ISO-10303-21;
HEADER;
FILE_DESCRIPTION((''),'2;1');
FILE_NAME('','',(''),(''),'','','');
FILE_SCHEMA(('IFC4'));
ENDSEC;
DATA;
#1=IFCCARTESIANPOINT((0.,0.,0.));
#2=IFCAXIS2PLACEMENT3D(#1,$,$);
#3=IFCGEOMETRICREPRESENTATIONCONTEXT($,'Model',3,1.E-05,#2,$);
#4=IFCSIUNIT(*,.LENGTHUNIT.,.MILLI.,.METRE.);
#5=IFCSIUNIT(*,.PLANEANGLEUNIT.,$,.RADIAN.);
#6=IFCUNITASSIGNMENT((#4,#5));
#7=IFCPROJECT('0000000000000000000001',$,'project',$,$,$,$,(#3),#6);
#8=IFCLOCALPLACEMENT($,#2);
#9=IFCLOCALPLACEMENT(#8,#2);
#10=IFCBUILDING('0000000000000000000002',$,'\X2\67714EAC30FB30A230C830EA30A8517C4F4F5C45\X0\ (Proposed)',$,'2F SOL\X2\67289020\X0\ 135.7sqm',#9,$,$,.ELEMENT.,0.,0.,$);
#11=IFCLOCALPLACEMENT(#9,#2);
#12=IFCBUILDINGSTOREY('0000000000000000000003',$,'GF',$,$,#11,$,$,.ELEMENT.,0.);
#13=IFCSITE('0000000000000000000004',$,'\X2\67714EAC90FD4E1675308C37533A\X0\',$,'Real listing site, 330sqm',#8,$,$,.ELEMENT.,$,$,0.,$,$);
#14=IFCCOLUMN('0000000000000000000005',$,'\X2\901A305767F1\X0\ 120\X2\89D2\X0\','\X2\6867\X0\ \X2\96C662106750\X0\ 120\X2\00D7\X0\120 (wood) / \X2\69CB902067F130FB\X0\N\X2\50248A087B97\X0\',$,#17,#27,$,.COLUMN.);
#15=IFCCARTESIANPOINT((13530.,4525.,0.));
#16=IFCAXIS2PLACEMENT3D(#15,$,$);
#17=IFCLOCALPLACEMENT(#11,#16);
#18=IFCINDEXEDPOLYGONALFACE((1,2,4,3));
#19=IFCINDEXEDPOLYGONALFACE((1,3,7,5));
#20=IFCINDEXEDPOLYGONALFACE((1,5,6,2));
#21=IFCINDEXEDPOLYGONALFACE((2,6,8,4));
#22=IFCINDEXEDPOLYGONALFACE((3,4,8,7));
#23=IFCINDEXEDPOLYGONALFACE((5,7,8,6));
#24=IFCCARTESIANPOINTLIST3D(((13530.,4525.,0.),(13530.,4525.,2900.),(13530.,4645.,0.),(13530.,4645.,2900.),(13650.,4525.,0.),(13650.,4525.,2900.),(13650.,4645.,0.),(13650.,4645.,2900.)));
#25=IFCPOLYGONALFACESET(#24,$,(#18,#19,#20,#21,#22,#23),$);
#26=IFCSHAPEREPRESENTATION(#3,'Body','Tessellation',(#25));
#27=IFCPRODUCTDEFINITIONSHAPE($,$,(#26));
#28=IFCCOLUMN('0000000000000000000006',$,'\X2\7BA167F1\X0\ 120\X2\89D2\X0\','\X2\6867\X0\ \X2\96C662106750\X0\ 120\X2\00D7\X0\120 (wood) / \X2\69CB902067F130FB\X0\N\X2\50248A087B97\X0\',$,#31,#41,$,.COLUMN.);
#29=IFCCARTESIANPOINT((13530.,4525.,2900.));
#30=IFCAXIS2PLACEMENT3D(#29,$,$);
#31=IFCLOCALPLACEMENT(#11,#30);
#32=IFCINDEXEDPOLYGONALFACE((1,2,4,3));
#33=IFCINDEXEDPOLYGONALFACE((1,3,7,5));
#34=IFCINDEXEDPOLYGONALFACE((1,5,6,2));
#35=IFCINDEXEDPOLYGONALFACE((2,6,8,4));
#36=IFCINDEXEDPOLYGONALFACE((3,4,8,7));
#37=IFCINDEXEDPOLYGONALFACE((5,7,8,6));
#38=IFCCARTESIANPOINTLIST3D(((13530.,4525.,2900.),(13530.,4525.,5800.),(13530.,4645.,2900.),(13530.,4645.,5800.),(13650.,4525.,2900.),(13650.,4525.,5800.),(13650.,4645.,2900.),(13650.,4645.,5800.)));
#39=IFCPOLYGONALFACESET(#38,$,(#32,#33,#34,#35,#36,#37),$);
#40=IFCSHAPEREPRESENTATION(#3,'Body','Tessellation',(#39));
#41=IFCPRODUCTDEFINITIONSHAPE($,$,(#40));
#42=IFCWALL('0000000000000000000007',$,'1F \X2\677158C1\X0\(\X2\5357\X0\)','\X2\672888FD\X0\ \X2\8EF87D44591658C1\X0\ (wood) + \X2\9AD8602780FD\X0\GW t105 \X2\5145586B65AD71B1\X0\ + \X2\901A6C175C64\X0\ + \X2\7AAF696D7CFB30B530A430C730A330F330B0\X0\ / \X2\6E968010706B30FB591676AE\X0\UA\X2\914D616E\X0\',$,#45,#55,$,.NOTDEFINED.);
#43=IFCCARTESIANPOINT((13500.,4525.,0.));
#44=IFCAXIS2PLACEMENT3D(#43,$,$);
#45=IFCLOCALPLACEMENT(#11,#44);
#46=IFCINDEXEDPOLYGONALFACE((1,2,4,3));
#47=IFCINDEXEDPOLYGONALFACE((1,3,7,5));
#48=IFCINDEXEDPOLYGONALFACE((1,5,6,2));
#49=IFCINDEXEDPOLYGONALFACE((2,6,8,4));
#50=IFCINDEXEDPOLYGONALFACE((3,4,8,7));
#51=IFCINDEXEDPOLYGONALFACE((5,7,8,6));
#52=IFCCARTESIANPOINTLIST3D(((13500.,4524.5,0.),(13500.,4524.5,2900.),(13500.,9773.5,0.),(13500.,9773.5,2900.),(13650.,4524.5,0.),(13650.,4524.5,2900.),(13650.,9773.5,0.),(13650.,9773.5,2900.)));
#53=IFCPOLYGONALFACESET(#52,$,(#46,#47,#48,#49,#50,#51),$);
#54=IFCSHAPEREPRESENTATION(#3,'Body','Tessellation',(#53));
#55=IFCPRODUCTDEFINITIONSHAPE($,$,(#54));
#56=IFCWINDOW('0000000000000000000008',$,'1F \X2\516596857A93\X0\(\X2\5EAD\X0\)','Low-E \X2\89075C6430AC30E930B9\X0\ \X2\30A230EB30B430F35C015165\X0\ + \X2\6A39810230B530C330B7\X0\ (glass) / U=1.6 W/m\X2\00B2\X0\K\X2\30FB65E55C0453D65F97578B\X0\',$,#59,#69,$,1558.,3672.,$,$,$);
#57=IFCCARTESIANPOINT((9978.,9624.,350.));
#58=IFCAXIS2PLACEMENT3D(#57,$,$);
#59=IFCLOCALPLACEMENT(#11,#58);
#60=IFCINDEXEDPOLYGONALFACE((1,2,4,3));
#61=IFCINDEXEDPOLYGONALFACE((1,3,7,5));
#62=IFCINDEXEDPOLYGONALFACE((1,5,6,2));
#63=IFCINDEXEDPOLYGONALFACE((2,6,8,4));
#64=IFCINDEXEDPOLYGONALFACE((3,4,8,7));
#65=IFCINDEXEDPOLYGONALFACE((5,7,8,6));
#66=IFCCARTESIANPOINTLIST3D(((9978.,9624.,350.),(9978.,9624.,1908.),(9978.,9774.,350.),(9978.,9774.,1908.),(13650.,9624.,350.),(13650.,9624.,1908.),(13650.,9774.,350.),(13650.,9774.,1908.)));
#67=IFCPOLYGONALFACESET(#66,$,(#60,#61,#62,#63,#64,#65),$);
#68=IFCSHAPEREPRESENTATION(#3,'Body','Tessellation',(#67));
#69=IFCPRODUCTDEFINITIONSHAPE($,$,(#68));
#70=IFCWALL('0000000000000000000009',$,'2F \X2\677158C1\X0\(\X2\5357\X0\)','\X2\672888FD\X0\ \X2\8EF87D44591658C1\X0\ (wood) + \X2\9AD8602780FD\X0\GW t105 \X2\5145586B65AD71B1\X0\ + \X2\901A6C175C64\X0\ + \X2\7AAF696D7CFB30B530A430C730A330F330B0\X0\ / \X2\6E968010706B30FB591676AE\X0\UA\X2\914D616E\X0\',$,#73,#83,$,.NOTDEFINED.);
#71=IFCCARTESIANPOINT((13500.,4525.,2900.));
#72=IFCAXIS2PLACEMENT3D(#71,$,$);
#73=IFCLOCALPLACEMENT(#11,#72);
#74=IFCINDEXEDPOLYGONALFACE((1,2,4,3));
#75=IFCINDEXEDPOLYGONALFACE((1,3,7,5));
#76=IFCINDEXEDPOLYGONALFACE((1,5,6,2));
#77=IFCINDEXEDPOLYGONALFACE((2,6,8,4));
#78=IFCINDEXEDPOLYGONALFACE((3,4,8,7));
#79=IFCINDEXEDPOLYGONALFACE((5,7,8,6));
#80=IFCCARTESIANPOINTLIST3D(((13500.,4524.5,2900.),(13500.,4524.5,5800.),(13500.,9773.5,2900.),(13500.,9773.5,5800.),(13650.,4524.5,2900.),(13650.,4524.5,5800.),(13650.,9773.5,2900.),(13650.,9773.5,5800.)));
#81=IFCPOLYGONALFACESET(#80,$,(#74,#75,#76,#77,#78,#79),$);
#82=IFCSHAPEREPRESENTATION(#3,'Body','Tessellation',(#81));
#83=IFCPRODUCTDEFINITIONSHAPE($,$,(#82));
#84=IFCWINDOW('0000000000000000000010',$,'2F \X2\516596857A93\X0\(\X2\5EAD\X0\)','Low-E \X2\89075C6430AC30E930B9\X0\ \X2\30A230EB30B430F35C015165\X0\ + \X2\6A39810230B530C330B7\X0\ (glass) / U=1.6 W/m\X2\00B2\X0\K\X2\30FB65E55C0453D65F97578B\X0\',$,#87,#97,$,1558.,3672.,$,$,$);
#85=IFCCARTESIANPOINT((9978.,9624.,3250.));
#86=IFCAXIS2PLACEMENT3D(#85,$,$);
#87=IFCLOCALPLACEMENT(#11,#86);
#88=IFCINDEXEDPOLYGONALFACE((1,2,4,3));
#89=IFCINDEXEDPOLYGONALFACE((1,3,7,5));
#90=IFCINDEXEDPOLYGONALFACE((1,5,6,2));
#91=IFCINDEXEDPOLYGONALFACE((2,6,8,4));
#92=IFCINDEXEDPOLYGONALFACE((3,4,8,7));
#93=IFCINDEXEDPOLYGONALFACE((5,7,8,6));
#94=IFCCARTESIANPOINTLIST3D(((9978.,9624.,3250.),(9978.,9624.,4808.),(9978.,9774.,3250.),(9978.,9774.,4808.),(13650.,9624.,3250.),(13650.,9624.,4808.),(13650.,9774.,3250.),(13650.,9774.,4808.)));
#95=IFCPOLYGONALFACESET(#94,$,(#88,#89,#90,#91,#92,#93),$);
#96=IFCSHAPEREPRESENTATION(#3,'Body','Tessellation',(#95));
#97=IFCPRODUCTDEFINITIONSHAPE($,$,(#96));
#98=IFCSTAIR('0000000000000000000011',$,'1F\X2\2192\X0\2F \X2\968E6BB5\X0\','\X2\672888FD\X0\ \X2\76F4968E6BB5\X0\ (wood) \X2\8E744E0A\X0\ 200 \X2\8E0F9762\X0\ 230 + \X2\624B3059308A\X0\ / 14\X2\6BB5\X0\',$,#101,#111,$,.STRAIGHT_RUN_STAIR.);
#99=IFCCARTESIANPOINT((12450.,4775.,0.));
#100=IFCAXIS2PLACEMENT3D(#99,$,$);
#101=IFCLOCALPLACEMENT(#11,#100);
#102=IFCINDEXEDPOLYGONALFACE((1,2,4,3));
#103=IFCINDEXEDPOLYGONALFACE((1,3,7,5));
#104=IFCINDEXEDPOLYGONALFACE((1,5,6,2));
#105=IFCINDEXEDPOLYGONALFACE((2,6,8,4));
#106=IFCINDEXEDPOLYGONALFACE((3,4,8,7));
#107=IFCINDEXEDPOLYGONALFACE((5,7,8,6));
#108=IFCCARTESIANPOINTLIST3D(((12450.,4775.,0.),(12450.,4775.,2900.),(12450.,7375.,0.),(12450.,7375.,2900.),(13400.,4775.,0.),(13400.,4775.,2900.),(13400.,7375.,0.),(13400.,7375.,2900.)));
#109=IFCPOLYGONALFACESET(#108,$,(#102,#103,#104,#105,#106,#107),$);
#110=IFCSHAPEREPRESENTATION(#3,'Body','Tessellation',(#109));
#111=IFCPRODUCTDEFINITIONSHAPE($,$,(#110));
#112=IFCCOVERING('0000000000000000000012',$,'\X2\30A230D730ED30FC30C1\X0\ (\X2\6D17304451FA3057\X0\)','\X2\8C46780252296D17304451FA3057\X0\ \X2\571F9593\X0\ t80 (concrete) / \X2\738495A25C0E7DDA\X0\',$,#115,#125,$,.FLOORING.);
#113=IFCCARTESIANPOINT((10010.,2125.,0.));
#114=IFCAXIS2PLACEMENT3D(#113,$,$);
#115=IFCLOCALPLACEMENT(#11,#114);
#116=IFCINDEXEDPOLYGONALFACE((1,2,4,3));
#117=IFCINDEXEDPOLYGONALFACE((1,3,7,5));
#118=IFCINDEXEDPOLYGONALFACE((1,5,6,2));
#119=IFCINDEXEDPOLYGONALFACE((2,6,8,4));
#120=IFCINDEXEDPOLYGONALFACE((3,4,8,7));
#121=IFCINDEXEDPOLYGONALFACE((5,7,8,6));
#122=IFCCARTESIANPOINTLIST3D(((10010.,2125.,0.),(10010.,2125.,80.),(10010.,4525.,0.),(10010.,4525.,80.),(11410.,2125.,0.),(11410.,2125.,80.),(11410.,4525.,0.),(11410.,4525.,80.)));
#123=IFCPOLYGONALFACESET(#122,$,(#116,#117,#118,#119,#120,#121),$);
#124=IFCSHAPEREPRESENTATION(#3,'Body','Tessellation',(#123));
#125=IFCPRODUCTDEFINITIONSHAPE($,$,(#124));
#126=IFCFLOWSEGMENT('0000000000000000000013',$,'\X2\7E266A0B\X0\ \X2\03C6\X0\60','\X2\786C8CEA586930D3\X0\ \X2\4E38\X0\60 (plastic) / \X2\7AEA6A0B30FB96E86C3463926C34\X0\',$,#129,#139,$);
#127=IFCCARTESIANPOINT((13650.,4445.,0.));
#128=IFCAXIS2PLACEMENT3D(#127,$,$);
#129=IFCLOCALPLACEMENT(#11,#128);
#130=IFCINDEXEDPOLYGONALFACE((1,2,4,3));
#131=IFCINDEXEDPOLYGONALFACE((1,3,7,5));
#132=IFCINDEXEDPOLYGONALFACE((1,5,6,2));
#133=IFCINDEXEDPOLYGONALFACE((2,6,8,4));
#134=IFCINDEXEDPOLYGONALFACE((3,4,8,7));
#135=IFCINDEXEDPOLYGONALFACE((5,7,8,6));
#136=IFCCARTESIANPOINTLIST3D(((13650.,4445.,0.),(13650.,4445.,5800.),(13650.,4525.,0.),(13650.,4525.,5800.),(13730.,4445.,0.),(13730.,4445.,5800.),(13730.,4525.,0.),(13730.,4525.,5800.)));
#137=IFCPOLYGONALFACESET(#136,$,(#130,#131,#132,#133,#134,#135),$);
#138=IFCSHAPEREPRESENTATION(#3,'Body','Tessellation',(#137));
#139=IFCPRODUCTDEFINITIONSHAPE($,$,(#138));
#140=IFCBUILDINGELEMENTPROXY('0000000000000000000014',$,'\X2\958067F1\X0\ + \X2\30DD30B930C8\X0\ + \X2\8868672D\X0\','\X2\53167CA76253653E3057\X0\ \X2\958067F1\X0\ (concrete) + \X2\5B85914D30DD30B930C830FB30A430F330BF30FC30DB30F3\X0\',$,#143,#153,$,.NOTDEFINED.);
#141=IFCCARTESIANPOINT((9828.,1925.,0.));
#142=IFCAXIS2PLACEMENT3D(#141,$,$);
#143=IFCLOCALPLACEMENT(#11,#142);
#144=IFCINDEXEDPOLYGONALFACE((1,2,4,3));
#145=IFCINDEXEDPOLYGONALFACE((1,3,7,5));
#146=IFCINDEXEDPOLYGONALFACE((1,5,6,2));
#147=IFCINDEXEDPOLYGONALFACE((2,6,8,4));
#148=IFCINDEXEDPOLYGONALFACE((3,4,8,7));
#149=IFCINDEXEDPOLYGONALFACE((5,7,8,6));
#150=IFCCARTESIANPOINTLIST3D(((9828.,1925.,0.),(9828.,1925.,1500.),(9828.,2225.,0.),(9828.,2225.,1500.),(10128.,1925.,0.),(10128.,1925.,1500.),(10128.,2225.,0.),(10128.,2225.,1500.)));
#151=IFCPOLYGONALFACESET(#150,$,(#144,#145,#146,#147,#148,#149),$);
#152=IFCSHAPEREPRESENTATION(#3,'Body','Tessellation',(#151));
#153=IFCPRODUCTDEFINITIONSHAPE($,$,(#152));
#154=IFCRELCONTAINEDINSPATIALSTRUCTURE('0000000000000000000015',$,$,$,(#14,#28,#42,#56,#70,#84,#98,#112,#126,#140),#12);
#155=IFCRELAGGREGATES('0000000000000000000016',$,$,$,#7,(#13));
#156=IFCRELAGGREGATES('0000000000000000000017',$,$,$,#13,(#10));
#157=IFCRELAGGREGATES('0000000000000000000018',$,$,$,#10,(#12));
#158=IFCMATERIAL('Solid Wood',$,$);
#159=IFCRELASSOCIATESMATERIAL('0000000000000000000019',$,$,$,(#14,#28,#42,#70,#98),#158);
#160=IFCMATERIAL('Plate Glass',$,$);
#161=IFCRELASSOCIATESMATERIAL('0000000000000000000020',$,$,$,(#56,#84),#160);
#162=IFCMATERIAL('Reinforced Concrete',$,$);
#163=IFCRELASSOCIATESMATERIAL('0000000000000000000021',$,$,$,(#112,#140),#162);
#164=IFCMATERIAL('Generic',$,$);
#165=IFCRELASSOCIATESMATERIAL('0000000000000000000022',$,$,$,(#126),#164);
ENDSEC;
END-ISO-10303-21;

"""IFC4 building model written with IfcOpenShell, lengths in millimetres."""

from ifc_helpers import new_model, si_unit, frame, frame_2d, origin, place, context, project, spatial, rectangle, extrude, material, element, fill, save


model = new_model("IFC4")

# Units and contexts
model_context = context("Model", 3, precision=1e-05, world=origin())
ifc_project = project(units=[si_unit("LENGTHUNIT", "METRE", prefix="MILLI"), si_unit("PLANEANGLEUNIT", "RADIAN")], contexts=[model_context])

# Site, building, storey
site_placement = place(None, origin())
site = spatial("IfcSite", under=ifc_project, at=site_placement, Name="東京都世田谷区", ObjectType="Real listing site, 330sqm", CompositionType="ELEMENT", RefElevation=0.0)
building_placement = place(site_placement, origin())
building = spatial("IfcBuilding", under=site, at=building_placement, Name="東京・アトリエ兼住居 (Proposed)", ObjectType="2F SOL木造 135.7sqm", CompositionType="ELEMENT", ElevationOfRefHeight=0.0, ElevationOfTerrain=0.0)
storey_placement = place(building_placement, origin())
storey = spatial("IfcBuildingStorey", under=building, at=storey_placement, Name="GF", CompositionType="ELEMENT", Elevation=0.0)

# Columns
ifc_material_1 = material(Name="Solid Wood")
column_1_placement = place(storey_placement, frame((13530.0, 4525.0, 0.0)))
element("IfcColumn", 1, at=column_1_placement, inside=storey, material=ifc_material_1, Name="通し柱 120角", Description="桧 集成材 120×120 (wood) / 構造柱・N値計算", PredefinedType="COLUMN", context=model_context, shape_type="SweptSolid", body=[
    extrude(rectangle(XDim=120.0, YDim=120.0, at=frame_2d((60.0, 60.0))), frame((13530.0, 4525.0, 0.0)), (0.0, 0.0, 1.0), 2900.0),
])
column_2_placement = place(storey_placement, frame((13530.0, 4525.0, 2900.0)))
element("IfcColumn", 2, at=column_2_placement, inside=storey, material=ifc_material_1, Name="管柱 120角", Description="桧 集成材 120×120 (wood) / 構造柱・N値計算", PredefinedType="COLUMN", context=model_context, shape_type="SweptSolid", body=[
    extrude(rectangle(XDim=120.0, YDim=120.0, at=frame_2d((60.0, 60.0))), frame((13530.0, 4525.0, 2900.0)), (0.0, 0.0, 1.0), 2900.0),
])

# Wall, opening, window
wall_1_placement = place(storey_placement, frame((13500.0, 4525.0, 0.0)))
wall_1 = element("IfcWall", 3, at=wall_1_placement, inside=storey, material=ifc_material_1, Name="1F 東壁(南)", Description="木製 軸組外壁 (wood) + 高性能GW t105 充填断熱 + 通気層 + 窯業系サイディング / 準耐火・外皮UA配慮", PredefinedType="NOTDEFINED", context=model_context, shape_type="SweptSolid", body=[
    extrude(rectangle(XDim=150.0, YDim=5249.0, at=frame_2d((75.0, 2624.0))), frame((13500.0, 4525.0, 0.0)), (0.0, 0.0, 1.0), 2900.0),
])
opening_1_placement = place(storey_placement, frame((9978.0, 9624.0, 350.0)))
opening_1 = element("IfcOpeningElement", 4, at=opening_1_placement, cuts=wall_1, PredefinedType="NOTDEFINED", context=model_context, shape_type="SweptSolid", body=[
    extrude(rectangle(XDim=3672.0, YDim=150.0, at=frame_2d((1836.0, 75.0))), frame((9978.0, 9624.0, 350.0)), (0.0, 0.0, 1.0), 1558.0),
])
ifc_material_2 = material(Name="Plate Glass")
window_1_placement = place(storey_placement, frame((9978.0, 9624.0, 350.0)))
window_1 = element("IfcWindow", 5, at=window_1_placement, inside=storey, material=ifc_material_2, Name="1F 入隅窓(庭)", Description="Low-E 複層ガラス アルゴン封入 + 樹脂サッシ (glass) / U=1.6 W/m²K・日射取得型", OverallHeight=1558.0, OverallWidth=3672.0, context=model_context, shape_type="SweptSolid", body=[
    extrude(rectangle(XDim=3672.0, YDim=150.0, at=frame_2d((1836.0, 75.0))), frame((9978.0, 9624.0, 350.0)), (0.0, 0.0, 1.0), 1558.0),
])
fill(opening_1, window_1)

# Wall, opening, window
wall_2_placement = place(storey_placement, frame((13500.0, 4525.0, 2900.0)))
wall_2 = element("IfcWall", 6, at=wall_2_placement, inside=storey, material=ifc_material_1, Name="2F 東壁(南)", Description="木製 軸組外壁 (wood) + 高性能GW t105 充填断熱 + 通気層 + 窯業系サイディング / 準耐火・外皮UA配慮", PredefinedType="NOTDEFINED", context=model_context, shape_type="SweptSolid", body=[
    extrude(rectangle(XDim=150.0, YDim=5249.0, at=frame_2d((75.0, 2624.0))), frame((13500.0, 4525.0, 2900.0)), (0.0, 0.0, 1.0), 2900.0),
])
opening_2_placement = place(storey_placement, frame((9978.0, 9624.0, 3250.0)))
opening_2 = element("IfcOpeningElement", 7, at=opening_2_placement, cuts=wall_2, PredefinedType="NOTDEFINED", context=model_context, shape_type="SweptSolid", body=[
    extrude(rectangle(XDim=3672.0, YDim=150.0, at=frame_2d((1836.0, 75.0))), frame((9978.0, 9624.0, 3250.0)), (0.0, 0.0, 1.0), 1558.0),
])
window_2_placement = place(storey_placement, frame((9978.0, 9624.0, 3250.0)))
window_2 = element("IfcWindow", 8, at=window_2_placement, inside=storey, material=ifc_material_2, Name="2F 入隅窓(庭)", Description="Low-E 複層ガラス アルゴン封入 + 樹脂サッシ (glass) / U=1.6 W/m²K・日射取得型", OverallHeight=1558.0, OverallWidth=3672.0, context=model_context, shape_type="SweptSolid", body=[
    extrude(rectangle(XDim=3672.0, YDim=150.0, at=frame_2d((1836.0, 75.0))), frame((9978.0, 9624.0, 3250.0)), (0.0, 0.0, 1.0), 1558.0),
])
fill(opening_2, window_2)

# Stair
stair_placement = place(storey_placement, frame((12450.0, 4775.0, 0.0)))
element("IfcStair", 9, at=stair_placement, inside=storey, material=ifc_material_1, Name="1F→2F 階段", Description="木製 直階段 (wood) 蹴上 200 踏面 230 + 手すり / 14段", PredefinedType="STRAIGHT_RUN_STAIR", context=model_context, shape_type="SweptSolid", body=[
    extrude(rectangle(XDim=950.0, YDim=2600.0, at=frame_2d((475.0, 1300.0))), frame((12450.0, 4775.0, 0.0)), (0.0, 0.0, 1.0), 2900.0),
])

# Covering
ifc_material_3 = material(Name="Reinforced Concrete")
covering_placement = place(storey_placement, frame((10010.0, 2125.0, 0.0)))
element("IfcCovering", 10, at=covering_placement, inside=storey, material=ifc_material_3, Name="アプローチ (洗い出し)", Description="豆砂利洗い出し 土間 t80 (concrete) / 玄関導線", PredefinedType="FLOORING", context=model_context, shape_type="SweptSolid", body=[
    extrude(rectangle(XDim=1400.0, YDim=2400.0, at=frame_2d((700.0, 1200.0))), frame((10010.0, 2125.0, 0.0)), (0.0, 0.0, 1.0), 80.0),
])

# Flow segment
ifc_material_4 = material(Name="Generic")
flow_segment_placement = place(storey_placement, frame((13650.0, 4445.0, 0.0)))
element("IfcFlowSegment", 11, at=flow_segment_placement, inside=storey, material=ifc_material_4, Name="縦樋 φ60", Description="硬質塩ビ 丸60 (plastic) / 竪樋・雨水排水", context=model_context, shape_type="SweptSolid", body=[
    extrude(rectangle(XDim=80.0, YDim=80.0, at=frame_2d((40.0, 40.0))), frame((13650.0, 4445.0, 0.0)), (0.0, 0.0, 1.0), 5800.0),
])

# Building element proxy
proxy_placement = place(storey_placement, frame((9828.0, 1925.0, 0.0)))
element("IfcBuildingElementProxy", 12, at=proxy_placement, inside=storey, material=ifc_material_3, Name="門柱 + ポスト + 表札", Description="化粧打放し 門柱 (concrete) + 宅配ポスト・インターホン", PredefinedType="NOTDEFINED", context=model_context, shape_type="SweptSolid", body=[
    extrude(rectangle(XDim=300.0, YDim=300.0, at=frame_2d((150.0, 150.0))), frame((9828.0, 1925.0, 0.0)), (0.0, 0.0, 1.0), 1500.0),
])

save(model, "model.ifc")
